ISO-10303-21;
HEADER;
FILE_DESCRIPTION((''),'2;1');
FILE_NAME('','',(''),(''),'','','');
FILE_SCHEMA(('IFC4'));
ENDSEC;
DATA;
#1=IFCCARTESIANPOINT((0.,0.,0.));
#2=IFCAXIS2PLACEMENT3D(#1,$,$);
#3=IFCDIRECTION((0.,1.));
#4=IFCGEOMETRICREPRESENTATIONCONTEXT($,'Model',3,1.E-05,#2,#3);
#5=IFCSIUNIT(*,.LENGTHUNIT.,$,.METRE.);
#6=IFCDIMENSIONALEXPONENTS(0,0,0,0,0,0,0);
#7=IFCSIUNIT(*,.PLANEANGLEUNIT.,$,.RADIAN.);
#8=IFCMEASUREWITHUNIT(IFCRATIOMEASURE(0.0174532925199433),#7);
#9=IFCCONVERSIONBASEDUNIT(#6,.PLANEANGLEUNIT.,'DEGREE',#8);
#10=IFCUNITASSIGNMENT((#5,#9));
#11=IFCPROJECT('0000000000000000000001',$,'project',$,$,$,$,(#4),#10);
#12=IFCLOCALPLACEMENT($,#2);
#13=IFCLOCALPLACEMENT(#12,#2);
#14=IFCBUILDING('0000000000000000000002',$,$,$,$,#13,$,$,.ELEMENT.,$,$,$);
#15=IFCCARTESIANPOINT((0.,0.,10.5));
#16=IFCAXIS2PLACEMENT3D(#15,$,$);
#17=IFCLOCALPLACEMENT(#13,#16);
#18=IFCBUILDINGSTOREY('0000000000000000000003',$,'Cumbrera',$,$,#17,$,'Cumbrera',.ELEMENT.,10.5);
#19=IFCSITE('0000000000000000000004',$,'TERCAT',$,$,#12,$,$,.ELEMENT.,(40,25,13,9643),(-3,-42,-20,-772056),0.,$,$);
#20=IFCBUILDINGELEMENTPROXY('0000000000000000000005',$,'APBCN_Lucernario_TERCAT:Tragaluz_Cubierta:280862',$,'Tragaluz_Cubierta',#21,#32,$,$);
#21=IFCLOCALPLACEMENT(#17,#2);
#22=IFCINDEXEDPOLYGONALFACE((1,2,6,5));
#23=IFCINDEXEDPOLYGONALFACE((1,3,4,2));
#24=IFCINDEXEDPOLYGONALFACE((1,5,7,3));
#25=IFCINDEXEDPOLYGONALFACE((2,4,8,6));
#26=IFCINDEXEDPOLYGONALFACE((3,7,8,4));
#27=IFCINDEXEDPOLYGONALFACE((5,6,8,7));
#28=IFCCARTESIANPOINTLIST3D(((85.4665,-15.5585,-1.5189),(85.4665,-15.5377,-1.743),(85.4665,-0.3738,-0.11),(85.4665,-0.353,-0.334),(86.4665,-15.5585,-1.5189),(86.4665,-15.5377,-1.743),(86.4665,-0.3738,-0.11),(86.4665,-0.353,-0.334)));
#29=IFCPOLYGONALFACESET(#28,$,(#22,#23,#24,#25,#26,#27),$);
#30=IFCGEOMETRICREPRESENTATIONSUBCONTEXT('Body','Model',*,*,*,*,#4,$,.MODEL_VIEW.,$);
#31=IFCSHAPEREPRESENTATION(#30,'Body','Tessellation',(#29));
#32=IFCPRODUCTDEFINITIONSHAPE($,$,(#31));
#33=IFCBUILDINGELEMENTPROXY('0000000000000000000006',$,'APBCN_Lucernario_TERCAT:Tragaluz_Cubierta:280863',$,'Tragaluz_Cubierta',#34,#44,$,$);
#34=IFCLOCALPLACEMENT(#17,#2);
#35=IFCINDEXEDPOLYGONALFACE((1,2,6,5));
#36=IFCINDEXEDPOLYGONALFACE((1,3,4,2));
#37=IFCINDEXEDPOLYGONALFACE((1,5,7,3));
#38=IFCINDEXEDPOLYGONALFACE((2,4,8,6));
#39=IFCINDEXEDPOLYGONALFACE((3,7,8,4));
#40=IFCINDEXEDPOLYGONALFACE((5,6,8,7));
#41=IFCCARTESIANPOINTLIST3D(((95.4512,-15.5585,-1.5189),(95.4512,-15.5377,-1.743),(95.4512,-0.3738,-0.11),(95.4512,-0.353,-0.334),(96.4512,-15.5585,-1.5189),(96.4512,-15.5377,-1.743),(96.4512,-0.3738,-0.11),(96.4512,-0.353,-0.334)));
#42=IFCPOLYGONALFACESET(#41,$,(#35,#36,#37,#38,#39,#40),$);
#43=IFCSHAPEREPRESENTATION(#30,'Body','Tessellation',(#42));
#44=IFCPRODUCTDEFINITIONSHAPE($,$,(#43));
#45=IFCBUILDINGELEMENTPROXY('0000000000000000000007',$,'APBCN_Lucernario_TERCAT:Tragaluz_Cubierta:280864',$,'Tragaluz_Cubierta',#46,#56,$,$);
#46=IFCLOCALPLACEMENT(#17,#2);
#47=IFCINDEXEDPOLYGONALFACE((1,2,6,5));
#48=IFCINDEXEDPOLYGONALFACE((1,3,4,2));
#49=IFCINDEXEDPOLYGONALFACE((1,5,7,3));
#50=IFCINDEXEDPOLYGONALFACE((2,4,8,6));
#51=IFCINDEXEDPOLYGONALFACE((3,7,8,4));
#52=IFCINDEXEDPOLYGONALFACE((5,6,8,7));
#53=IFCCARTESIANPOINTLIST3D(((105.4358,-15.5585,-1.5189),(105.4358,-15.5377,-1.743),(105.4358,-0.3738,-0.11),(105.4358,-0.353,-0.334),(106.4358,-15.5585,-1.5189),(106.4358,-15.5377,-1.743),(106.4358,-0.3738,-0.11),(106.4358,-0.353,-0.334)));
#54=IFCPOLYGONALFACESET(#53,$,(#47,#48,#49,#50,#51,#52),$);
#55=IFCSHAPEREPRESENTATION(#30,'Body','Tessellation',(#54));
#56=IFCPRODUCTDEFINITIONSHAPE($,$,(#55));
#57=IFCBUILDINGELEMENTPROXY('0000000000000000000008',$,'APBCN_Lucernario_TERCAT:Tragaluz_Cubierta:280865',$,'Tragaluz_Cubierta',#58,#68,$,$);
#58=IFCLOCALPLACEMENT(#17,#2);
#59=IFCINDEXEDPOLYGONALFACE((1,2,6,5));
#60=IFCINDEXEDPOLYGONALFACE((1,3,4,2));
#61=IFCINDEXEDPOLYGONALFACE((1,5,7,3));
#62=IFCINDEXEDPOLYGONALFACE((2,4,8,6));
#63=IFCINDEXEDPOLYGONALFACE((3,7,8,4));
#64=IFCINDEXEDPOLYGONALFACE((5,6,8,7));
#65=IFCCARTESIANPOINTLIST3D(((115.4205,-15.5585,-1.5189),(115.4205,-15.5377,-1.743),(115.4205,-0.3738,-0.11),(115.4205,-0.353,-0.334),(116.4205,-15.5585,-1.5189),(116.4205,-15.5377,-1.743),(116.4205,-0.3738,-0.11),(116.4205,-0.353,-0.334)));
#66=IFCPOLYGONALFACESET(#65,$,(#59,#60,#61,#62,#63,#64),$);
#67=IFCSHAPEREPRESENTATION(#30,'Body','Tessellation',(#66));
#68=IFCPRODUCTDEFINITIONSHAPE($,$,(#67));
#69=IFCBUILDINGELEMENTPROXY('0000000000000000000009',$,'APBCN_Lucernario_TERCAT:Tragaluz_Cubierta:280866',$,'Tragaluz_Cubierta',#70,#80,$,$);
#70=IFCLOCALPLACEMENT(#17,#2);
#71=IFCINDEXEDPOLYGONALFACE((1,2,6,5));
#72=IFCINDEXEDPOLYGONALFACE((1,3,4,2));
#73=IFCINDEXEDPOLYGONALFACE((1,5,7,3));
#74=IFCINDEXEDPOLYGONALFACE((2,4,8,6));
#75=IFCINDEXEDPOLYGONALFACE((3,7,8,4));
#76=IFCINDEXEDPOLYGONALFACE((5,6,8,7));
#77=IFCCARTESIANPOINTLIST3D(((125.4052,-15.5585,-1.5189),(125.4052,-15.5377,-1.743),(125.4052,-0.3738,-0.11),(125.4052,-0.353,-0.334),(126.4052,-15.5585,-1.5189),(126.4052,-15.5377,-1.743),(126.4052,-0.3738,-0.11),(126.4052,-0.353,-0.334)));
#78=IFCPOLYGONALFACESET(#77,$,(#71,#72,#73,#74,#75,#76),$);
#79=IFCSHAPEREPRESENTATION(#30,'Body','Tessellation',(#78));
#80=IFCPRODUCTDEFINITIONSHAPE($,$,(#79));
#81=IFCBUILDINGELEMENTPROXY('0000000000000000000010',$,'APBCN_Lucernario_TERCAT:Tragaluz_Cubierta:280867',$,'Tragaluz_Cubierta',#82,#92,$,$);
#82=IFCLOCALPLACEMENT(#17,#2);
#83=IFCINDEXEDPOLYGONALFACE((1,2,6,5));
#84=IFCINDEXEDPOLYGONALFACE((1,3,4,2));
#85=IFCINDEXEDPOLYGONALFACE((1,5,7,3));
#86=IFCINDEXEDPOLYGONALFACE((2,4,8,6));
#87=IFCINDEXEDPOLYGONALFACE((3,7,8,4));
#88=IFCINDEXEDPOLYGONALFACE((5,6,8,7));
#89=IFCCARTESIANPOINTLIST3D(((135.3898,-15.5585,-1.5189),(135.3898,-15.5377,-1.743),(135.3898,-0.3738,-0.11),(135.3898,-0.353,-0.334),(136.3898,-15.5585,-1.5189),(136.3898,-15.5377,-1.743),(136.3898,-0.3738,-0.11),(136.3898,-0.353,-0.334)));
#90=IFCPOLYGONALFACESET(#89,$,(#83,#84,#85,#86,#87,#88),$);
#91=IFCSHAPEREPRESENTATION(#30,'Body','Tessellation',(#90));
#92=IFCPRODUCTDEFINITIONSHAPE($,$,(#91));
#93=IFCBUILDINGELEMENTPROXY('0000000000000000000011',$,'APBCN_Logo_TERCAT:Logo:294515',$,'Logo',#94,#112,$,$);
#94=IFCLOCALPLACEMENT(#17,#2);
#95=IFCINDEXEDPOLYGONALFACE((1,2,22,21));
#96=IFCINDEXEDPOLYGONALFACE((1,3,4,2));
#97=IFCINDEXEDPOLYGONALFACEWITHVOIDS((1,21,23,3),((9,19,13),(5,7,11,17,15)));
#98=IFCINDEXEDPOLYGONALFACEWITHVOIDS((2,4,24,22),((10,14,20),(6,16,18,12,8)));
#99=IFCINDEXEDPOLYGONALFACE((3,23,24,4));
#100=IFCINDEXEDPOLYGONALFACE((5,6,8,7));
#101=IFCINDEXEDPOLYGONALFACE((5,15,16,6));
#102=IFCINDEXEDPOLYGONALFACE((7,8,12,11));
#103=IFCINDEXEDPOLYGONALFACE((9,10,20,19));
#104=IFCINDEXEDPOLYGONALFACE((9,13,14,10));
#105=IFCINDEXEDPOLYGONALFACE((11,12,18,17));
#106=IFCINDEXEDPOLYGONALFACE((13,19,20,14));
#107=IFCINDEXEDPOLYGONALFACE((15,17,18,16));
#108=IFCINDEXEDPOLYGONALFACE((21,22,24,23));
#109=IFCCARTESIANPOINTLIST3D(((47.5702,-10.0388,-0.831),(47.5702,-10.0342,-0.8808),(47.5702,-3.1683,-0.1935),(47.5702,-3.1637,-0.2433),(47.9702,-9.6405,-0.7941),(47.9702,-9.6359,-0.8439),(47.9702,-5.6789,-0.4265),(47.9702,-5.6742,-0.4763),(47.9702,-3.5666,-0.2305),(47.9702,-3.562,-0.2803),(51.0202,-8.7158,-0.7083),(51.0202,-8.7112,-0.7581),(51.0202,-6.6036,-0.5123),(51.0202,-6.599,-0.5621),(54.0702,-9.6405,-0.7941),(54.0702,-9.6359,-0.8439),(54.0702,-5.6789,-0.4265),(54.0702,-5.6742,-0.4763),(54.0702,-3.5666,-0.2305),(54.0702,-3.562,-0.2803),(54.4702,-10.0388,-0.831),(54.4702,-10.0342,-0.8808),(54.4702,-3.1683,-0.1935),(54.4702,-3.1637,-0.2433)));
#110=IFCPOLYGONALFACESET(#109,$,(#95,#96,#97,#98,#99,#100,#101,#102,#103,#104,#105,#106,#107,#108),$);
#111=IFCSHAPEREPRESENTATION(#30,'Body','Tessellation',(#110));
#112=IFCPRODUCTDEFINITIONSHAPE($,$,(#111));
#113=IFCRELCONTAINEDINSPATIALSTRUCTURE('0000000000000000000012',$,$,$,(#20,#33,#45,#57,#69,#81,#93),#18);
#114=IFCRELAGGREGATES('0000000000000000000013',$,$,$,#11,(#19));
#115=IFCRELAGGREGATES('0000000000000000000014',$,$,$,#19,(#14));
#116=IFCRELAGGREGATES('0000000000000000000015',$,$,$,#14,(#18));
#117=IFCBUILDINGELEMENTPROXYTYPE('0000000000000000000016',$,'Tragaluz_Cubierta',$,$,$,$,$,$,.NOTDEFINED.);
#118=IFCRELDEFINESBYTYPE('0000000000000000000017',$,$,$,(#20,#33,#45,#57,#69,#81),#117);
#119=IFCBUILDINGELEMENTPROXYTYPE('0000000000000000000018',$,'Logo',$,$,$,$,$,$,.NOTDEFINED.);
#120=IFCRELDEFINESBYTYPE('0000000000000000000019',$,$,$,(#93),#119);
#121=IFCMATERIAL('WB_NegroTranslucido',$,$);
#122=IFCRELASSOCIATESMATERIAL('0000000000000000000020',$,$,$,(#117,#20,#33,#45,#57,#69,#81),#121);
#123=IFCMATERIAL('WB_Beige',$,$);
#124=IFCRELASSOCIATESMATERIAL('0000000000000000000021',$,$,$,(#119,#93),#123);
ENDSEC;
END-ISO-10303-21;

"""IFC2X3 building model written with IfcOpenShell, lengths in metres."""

from ifc_helpers import new_model, entity, si_unit, converted_unit, direction, frame, origin, origin_2d_with_axis, place, context, subcontext, project, spatial, polyline, rectangle, outline, extrude, source, transform, mapped, material, type_object, type_shapes, element, save


model = new_model("IFC2X3")

# Units and contexts
model_context = context("Model", 3, precision=1e-05, world=origin(), true_north=direction((0.0, 1.0)))
body_context = subcontext(model_context, "Body", "Model", "MODEL_VIEW")
ifc_project = project(units=[si_unit("LENGTHUNIT", "METRE"), converted_unit("PLANEANGLEUNIT", "DEGREE", entity("IfcRatioMeasure", 0.0174532925199433), si_unit("PLANEANGLEUNIT", "RADIAN"), dimensions=[0, 0, 0, 0, 0, 0, 0])], contexts=[model_context])

# Site, building, storey
site_placement = place(None, origin())
site = spatial("IfcSite", under=ifc_project, at=site_placement, Name="TERCAT", CompositionType="ELEMENT", RefLatitude=(40, 25, 13, 9643), RefLongitude=(-3, -42, -20, -772056), RefElevation=0.0)
building_placement = place(site_placement, origin())
building = spatial("IfcBuilding", under=site, at=building_placement, CompositionType="ELEMENT")
storey_placement = place(building_placement, frame((0.0, 0.0, 10.5)))
storey = spatial("IfcBuildingStorey", under=building, at=storey_placement, Name="Cumbrera", LongName="Cumbrera", CompositionType="ELEMENT", Elevation=10.5)

# Building element proxies
ifc_material_1 = material(Name="WB_NegroTranslucido")
building_element_proxy_type_1 = type_object("IfcBuildingElementProxyType", Name="Tragaluz_Cubierta", PredefinedType="NOTDEFINED", material=ifc_material_1)
shared_shape_1 = source(origin(), body_context, "Body", "SweptSolid", [
    extrude(rectangle(XDim=15.25, YDim=1.0, at=origin_2d_with_axis()), frame((0.5, 7.625, 0.0), z_axis=(0.0, 0.0, 1.0), x_axis=(0.0, 1.0, 0.0)), (0.0, 0.0, 1.0), 0.225),
])
type_shapes(building_element_proxy_type_1, [shared_shape_1])
for number, where, z_axis, x_axis, name in (
    (1, (86.4665, -0.353, -0.334), (0.0, -0.09239, 0.995723), (-1.0, 0.0, 0.0), "APBCN_Lucernario_TERCAT:Tragaluz_Cubierta:280862"),
    (2, (96.4512, -0.353, -0.334), (0.0, -0.09239, 0.995723), (-1.0, 0.0, 0.0), "APBCN_Lucernario_TERCAT:Tragaluz_Cubierta:280863"),
    (3, (106.4358, -0.353, -0.334), (0.0, -0.09239, 0.995723), (-1.0, 0.0, 0.0), "APBCN_Lucernario_TERCAT:Tragaluz_Cubierta:280864"),
    (4, (116.4205, -0.353, -0.334), (0.0, -0.09239, 0.995723), (-1.0, 0.0, 0.0), "APBCN_Lucernario_TERCAT:Tragaluz_Cubierta:280865"),
    (5, (126.4052, -0.353, -0.334), (0.0, -0.09239, 0.995723), (-1.0, 0.0, 0.0), "APBCN_Lucernario_TERCAT:Tragaluz_Cubierta:280866"),
    (6, (136.3898, -0.353, -0.334), (0.0, -0.09239, 0.995723), (-1.0, 0.0, 0.0), "APBCN_Lucernario_TERCAT:Tragaluz_Cubierta:280867"),
):
    element("IfcBuildingElementProxy", number, at=place(storey_placement, frame(where, z_axis=z_axis, x_axis=x_axis)), inside=storey, type_object=building_element_proxy_type_1, material=ifc_material_1, Name=name, ObjectType="Tragaluz_Cubierta", context=body_context, shape_type="MappedRepresentation", body=[
        mapped(shared_shape_1, transform((0.0, 0.0, 0.0), scale=1.0)),
    ])
ifc_material_2 = material(Name="WB_Beige")
building_element_proxy_type_2 = type_object("IfcBuildingElementProxyType", Name="Logo", PredefinedType="NOTDEFINED", material=ifc_material_2)
shared_shape_2 = source(origin(), body_context, "Body", "SweptSolid", [
    extrude(outline(polyline([(-3.45, -3.45), (3.45, -3.45), (3.45, 3.45), (-3.45, 3.45), (-3.45, -3.45)]), holes=[polyline([(3.05, -0.9287), (0.0, 2.1213), (-3.05, -0.9287), (-3.05, 3.05), (3.05, 3.05), (3.05, -0.9287)]), polyline([(-3.05, -3.05), (0.0, 0.0), (3.05, -3.05), (-3.05, -3.05)])]), frame((0.0, 0.0, 0.0), z_axis=(0.0, 0.0, 1.0), x_axis=(-1.0, 0.0, 0.0)), (0.0, 0.0, 1.0), 0.05),
])
type_shapes(building_element_proxy_type_2, [shared_shape_2])
proxy_1_placement = place(storey_placement, frame((51.0202, -6.599, -0.5621), z_axis=(0.0, -0.09239, 0.995723), x_axis=(1.0, 0.0, 0.0)))
element("IfcBuildingElementProxy", 7, at=proxy_1_placement, inside=storey, type_object=building_element_proxy_type_2, material=ifc_material_2, Name="APBCN_Logo_TERCAT:Logo:294515", ObjectType="Logo", context=body_context, shape_type="MappedRepresentation", body=[
    mapped(shared_shape_2, transform((0.0, 0.0, 0.0), scale=1.0)),
])

save(model, "model.ifc")
